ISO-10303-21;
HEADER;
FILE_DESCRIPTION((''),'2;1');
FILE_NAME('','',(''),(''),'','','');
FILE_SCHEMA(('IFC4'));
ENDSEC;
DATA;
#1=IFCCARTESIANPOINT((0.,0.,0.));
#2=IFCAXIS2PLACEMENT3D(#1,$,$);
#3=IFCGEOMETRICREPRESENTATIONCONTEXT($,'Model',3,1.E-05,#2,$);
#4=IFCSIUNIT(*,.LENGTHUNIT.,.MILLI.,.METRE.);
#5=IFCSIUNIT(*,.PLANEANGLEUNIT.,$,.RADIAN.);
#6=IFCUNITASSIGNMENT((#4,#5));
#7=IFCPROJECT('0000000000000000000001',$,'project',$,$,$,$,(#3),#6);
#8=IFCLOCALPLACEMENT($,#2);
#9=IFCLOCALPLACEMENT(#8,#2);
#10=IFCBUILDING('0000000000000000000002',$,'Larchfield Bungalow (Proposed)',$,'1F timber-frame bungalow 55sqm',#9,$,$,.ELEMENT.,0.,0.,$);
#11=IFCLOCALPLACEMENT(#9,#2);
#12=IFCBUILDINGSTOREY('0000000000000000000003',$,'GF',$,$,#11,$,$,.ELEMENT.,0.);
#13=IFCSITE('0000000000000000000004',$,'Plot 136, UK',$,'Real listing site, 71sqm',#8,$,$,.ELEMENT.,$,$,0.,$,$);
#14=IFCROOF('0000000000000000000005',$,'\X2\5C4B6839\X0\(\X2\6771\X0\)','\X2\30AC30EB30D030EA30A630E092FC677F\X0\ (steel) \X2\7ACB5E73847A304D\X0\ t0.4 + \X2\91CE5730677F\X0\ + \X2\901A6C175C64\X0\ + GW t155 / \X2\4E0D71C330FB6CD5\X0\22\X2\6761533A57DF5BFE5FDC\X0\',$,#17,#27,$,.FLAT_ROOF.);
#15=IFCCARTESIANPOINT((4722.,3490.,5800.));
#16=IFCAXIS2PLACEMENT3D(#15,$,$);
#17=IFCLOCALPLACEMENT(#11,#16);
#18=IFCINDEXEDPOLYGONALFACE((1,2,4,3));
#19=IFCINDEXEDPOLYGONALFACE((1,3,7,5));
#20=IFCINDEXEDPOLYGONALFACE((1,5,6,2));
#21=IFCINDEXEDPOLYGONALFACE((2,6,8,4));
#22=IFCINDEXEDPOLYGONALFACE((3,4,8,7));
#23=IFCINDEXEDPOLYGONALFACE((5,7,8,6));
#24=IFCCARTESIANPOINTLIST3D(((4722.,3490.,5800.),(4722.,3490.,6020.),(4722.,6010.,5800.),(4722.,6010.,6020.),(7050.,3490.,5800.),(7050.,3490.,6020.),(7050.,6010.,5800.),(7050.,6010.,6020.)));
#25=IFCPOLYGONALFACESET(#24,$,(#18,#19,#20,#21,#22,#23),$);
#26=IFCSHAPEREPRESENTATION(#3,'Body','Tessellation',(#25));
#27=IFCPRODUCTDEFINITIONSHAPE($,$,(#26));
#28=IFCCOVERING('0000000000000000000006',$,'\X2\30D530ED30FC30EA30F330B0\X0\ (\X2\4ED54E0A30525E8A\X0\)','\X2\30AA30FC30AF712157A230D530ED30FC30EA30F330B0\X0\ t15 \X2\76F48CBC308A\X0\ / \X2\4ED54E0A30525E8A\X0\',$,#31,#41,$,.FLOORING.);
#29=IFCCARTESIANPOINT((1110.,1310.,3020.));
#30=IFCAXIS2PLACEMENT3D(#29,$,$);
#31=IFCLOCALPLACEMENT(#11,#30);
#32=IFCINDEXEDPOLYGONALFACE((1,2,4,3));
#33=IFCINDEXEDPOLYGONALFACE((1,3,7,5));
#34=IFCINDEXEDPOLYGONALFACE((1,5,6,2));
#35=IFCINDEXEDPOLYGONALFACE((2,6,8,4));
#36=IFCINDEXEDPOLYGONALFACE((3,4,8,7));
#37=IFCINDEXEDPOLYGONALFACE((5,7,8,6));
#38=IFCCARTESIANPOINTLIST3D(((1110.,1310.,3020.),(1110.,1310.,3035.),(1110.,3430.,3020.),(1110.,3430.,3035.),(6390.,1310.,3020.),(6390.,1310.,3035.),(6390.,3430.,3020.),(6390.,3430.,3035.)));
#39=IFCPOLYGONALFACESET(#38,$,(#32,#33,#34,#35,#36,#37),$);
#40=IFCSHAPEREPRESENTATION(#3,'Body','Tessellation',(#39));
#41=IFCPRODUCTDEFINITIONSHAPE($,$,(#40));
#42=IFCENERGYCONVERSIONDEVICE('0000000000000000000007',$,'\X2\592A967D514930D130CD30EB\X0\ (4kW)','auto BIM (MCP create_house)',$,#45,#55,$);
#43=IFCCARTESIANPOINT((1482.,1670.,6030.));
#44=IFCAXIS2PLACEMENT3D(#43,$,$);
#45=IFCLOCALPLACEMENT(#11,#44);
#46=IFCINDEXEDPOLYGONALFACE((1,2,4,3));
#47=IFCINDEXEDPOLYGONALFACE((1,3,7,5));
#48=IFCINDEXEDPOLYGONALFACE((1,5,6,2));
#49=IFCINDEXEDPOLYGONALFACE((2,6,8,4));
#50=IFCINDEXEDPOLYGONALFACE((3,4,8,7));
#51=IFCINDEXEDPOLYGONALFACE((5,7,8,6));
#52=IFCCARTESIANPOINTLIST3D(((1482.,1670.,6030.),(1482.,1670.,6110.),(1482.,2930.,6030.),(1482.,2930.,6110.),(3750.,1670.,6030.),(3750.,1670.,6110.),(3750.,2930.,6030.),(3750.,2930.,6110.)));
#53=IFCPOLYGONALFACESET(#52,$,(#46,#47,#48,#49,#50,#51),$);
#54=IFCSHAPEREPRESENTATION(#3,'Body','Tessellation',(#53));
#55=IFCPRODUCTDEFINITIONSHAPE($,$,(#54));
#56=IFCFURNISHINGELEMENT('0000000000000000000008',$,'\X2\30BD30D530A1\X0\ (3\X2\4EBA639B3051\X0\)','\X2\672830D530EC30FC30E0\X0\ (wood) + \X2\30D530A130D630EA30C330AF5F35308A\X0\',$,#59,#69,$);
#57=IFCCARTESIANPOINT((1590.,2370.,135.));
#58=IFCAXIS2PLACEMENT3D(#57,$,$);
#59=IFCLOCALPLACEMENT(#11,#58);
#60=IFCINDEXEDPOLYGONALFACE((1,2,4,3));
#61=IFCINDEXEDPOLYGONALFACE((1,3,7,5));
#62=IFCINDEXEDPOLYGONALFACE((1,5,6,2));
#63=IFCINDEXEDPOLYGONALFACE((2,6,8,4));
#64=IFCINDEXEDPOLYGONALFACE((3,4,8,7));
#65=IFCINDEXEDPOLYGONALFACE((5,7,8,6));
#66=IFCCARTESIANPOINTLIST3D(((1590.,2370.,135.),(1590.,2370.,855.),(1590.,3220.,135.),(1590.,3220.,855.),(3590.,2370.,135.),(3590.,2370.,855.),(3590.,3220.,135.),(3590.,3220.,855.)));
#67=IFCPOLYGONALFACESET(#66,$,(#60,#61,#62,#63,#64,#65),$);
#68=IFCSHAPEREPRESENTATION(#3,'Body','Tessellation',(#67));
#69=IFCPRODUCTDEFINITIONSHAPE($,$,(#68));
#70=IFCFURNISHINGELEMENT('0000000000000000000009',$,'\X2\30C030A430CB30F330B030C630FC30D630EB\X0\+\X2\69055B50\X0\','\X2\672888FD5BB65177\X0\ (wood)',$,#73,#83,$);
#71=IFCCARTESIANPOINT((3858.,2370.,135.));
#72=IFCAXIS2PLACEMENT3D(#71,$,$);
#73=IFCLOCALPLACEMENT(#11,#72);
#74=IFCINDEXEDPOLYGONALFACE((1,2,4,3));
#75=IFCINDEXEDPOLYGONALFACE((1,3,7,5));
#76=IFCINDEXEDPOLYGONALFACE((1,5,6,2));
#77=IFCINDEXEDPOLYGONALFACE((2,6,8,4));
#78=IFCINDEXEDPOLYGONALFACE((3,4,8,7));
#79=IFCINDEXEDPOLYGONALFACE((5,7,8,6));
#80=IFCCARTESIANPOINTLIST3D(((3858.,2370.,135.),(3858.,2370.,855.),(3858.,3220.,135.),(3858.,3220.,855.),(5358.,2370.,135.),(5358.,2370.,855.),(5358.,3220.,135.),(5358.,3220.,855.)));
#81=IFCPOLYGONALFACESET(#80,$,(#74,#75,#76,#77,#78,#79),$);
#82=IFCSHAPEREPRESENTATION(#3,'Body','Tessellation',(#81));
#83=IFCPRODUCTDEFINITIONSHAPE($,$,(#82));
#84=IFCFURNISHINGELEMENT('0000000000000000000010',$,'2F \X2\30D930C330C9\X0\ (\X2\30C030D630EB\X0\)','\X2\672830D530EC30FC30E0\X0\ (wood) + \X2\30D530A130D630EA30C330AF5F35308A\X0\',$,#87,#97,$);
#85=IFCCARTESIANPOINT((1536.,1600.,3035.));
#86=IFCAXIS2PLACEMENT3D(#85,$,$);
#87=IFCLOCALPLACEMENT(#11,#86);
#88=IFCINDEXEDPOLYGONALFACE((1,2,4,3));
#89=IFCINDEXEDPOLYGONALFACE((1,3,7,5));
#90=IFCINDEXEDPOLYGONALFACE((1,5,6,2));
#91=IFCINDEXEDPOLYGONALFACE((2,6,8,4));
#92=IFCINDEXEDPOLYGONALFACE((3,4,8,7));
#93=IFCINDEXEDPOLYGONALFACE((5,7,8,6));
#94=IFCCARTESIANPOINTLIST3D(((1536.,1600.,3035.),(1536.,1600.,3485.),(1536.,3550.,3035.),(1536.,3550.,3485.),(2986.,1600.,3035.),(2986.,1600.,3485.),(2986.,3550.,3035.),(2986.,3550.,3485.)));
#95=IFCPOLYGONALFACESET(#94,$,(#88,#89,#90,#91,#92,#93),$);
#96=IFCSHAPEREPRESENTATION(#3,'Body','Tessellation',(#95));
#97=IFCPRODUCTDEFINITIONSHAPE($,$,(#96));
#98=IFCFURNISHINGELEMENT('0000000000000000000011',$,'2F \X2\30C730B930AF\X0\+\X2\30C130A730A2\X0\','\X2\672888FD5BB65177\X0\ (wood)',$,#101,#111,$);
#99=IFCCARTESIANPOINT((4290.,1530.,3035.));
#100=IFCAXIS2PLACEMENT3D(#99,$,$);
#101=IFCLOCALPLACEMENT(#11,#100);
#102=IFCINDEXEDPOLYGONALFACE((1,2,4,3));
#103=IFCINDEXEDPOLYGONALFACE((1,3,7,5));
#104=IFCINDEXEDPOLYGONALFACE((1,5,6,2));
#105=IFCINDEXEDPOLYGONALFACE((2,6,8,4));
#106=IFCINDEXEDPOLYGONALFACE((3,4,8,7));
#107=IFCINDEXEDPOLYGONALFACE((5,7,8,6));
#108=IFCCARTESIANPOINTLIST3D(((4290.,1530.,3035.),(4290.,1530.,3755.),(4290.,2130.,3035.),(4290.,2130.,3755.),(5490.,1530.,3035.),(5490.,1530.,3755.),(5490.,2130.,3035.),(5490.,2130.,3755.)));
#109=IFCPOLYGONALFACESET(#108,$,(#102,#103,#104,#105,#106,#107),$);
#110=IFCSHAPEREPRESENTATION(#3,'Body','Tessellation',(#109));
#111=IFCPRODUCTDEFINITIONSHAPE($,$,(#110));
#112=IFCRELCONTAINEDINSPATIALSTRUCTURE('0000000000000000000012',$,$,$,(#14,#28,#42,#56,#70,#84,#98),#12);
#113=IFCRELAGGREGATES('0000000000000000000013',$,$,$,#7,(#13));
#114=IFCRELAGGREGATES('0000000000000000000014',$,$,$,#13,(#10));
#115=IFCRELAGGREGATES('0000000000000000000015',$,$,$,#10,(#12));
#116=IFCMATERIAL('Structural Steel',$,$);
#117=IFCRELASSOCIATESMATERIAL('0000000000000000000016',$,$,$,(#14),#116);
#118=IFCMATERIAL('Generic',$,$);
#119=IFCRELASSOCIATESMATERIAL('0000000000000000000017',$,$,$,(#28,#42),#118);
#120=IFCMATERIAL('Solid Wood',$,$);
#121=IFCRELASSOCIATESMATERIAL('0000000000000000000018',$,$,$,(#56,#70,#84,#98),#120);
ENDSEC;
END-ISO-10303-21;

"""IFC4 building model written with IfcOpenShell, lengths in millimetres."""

from ifc_helpers import new_model, si_unit, frame, frame_2d, origin, place, context, project, spatial, rectangle, extrude, material, element, save


model = new_model("IFC4")

# Units and contexts
model_context = context("Model", 3, precision=1e-05, world=origin())
ifc_project = project(units=[si_unit("LENGTHUNIT", "METRE", prefix="MILLI"), si_unit("PLANEANGLEUNIT", "RADIAN")], contexts=[model_context])

# Site, building, storey
site_placement = place(None, origin())
site = spatial("IfcSite", under=ifc_project, at=site_placement, Name="Plot 136, UK", ObjectType="Real listing site, 71sqm", CompositionType="ELEMENT", RefElevation=0.0)
building_placement = place(site_placement, origin())
building = spatial("IfcBuilding", under=site, at=building_placement, Name="Larchfield Bungalow (Proposed)", ObjectType="1F timber-frame bungalow 55sqm", CompositionType="ELEMENT", ElevationOfRefHeight=0.0, ElevationOfTerrain=0.0)
storey_placement = place(building_placement, origin())
storey = spatial("IfcBuildingStorey", under=building, at=storey_placement, Name="GF", CompositionType="ELEMENT", Elevation=0.0)

# Shared definitions
ifc_material_1 = material(Name="Solid Wood")

# Roof
ifc_material_2 = material(Name="Structural Steel")
roof_1_placement = place(storey_placement, frame((4722.0, 3490.0, 5800.0)))
element("IfcRoof", 1, at=roof_1_placement, inside=storey, material=ifc_material_2, Name="屋根(東)", Description="ガルバリウム鋼板 (steel) 立平葺き t0.4 + 野地板 + 通気層 + GW t155 / 不燃・法22条区域対応", PredefinedType="FLAT_ROOF", context=model_context, shape_type="SweptSolid", body=[
    extrude(rectangle(XDim=2328.0, YDim=2520.0, at=frame_2d((1164.0, 1260.0))), frame((4722.0, 3490.0, 5800.0)), (0.0, 0.0, 1.0), 220.0),
])

# Covering
ifc_material_3 = material(Name="Generic")
covering_placement = place(storey_placement, frame((1110.0, 1310.0, 3020.0)))
element("IfcCovering", 2, at=covering_placement, inside=storey, material=ifc_material_3, Name="フローリング (仕上げ床)", Description="オーク無垢フローリング t15 直貼り / 仕上げ床", PredefinedType="FLOORING", context=model_context, shape_type="SweptSolid", body=[
    extrude(rectangle(XDim=5280.0, YDim=2120.0, at=frame_2d((2640.0, 1060.0))), frame((1110.0, 1310.0, 3020.0)), (0.0, 0.0, 1.0), 15.0),
])

# Energy conversion device
energy_conversion_device_placement = place(storey_placement, frame((1482.0, 1670.0, 6030.0)))
element("IfcEnergyConversionDevice", 3, at=energy_conversion_device_placement, inside=storey, material=ifc_material_3, Name="太陽光パネル (4kW)", Description="auto BIM (MCP create_house)", context=model_context, shape_type="SweptSolid", body=[
    extrude(rectangle(XDim=2268.0, YDim=1260.0, at=frame_2d((1134.0, 630.0))), frame((1482.0, 1670.0, 6030.0)), (0.0, 0.0, 1.0), 80.0),
])

# Furnishing elements
furnishing_1_placement = place(storey_placement, frame((1590.0, 2370.0, 135.0)))
element("IfcFurnishingElement", 4, at=furnishing_1_placement, inside=storey, material=ifc_material_1, Name="ソファ (3人掛け)", Description="木フレーム (wood) + ファブリック張り", context=model_context, shape_type="SweptSolid", body=[
    extrude(rectangle(XDim=2000.0, YDim=850.0, at=frame_2d((1000.0, 425.0))), frame((1590.0, 2370.0, 135.0)), (0.0, 0.0, 1.0), 720.0),
])
furnishing_2_placement = place(storey_placement, frame((3858.0, 2370.0, 135.0)))
element("IfcFurnishingElement", 5, at=furnishing_2_placement, inside=storey, material=ifc_material_1, Name="ダイニングテーブル+椅子", Description="木製家具 (wood)", context=model_context, shape_type="SweptSolid", body=[
    extrude(rectangle(XDim=1500.0, YDim=850.0, at=frame_2d((750.0, 425.0))), frame((3858.0, 2370.0, 135.0)), (0.0, 0.0, 1.0), 720.0),
])
furnishing_3_placement = place(storey_placement, frame((1536.0, 1600.0, 3035.0)))
element("IfcFurnishingElement", 6, at=furnishing_3_placement, inside=storey, material=ifc_material_1, Name="2F ベッド (ダブル)", Description="木フレーム (wood) + ファブリック張り", context=model_context, shape_type="SweptSolid", body=[
    extrude(rectangle(XDim=1450.0, YDim=1950.0, at=frame_2d((725.0, 975.0))), frame((1536.0, 1600.0, 3035.0)), (0.0, 0.0, 1.0), 450.0),
])
furnishing_4_placement = place(storey_placement, frame((4290.0, 1530.0, 3035.0)))
element("IfcFurnishingElement", 7, at=furnishing_4_placement, inside=storey, material=ifc_material_1, Name="2F デスク+チェア", Description="木製家具 (wood)", context=model_context, shape_type="SweptSolid", body=[
    extrude(rectangle(XDim=1200.0, YDim=600.0, at=frame_2d((600.0, 300.0))), frame((4290.0, 1530.0, 3035.0)), (0.0, 0.0, 1.0), 720.0),
])

save(model, "model.ifc")
